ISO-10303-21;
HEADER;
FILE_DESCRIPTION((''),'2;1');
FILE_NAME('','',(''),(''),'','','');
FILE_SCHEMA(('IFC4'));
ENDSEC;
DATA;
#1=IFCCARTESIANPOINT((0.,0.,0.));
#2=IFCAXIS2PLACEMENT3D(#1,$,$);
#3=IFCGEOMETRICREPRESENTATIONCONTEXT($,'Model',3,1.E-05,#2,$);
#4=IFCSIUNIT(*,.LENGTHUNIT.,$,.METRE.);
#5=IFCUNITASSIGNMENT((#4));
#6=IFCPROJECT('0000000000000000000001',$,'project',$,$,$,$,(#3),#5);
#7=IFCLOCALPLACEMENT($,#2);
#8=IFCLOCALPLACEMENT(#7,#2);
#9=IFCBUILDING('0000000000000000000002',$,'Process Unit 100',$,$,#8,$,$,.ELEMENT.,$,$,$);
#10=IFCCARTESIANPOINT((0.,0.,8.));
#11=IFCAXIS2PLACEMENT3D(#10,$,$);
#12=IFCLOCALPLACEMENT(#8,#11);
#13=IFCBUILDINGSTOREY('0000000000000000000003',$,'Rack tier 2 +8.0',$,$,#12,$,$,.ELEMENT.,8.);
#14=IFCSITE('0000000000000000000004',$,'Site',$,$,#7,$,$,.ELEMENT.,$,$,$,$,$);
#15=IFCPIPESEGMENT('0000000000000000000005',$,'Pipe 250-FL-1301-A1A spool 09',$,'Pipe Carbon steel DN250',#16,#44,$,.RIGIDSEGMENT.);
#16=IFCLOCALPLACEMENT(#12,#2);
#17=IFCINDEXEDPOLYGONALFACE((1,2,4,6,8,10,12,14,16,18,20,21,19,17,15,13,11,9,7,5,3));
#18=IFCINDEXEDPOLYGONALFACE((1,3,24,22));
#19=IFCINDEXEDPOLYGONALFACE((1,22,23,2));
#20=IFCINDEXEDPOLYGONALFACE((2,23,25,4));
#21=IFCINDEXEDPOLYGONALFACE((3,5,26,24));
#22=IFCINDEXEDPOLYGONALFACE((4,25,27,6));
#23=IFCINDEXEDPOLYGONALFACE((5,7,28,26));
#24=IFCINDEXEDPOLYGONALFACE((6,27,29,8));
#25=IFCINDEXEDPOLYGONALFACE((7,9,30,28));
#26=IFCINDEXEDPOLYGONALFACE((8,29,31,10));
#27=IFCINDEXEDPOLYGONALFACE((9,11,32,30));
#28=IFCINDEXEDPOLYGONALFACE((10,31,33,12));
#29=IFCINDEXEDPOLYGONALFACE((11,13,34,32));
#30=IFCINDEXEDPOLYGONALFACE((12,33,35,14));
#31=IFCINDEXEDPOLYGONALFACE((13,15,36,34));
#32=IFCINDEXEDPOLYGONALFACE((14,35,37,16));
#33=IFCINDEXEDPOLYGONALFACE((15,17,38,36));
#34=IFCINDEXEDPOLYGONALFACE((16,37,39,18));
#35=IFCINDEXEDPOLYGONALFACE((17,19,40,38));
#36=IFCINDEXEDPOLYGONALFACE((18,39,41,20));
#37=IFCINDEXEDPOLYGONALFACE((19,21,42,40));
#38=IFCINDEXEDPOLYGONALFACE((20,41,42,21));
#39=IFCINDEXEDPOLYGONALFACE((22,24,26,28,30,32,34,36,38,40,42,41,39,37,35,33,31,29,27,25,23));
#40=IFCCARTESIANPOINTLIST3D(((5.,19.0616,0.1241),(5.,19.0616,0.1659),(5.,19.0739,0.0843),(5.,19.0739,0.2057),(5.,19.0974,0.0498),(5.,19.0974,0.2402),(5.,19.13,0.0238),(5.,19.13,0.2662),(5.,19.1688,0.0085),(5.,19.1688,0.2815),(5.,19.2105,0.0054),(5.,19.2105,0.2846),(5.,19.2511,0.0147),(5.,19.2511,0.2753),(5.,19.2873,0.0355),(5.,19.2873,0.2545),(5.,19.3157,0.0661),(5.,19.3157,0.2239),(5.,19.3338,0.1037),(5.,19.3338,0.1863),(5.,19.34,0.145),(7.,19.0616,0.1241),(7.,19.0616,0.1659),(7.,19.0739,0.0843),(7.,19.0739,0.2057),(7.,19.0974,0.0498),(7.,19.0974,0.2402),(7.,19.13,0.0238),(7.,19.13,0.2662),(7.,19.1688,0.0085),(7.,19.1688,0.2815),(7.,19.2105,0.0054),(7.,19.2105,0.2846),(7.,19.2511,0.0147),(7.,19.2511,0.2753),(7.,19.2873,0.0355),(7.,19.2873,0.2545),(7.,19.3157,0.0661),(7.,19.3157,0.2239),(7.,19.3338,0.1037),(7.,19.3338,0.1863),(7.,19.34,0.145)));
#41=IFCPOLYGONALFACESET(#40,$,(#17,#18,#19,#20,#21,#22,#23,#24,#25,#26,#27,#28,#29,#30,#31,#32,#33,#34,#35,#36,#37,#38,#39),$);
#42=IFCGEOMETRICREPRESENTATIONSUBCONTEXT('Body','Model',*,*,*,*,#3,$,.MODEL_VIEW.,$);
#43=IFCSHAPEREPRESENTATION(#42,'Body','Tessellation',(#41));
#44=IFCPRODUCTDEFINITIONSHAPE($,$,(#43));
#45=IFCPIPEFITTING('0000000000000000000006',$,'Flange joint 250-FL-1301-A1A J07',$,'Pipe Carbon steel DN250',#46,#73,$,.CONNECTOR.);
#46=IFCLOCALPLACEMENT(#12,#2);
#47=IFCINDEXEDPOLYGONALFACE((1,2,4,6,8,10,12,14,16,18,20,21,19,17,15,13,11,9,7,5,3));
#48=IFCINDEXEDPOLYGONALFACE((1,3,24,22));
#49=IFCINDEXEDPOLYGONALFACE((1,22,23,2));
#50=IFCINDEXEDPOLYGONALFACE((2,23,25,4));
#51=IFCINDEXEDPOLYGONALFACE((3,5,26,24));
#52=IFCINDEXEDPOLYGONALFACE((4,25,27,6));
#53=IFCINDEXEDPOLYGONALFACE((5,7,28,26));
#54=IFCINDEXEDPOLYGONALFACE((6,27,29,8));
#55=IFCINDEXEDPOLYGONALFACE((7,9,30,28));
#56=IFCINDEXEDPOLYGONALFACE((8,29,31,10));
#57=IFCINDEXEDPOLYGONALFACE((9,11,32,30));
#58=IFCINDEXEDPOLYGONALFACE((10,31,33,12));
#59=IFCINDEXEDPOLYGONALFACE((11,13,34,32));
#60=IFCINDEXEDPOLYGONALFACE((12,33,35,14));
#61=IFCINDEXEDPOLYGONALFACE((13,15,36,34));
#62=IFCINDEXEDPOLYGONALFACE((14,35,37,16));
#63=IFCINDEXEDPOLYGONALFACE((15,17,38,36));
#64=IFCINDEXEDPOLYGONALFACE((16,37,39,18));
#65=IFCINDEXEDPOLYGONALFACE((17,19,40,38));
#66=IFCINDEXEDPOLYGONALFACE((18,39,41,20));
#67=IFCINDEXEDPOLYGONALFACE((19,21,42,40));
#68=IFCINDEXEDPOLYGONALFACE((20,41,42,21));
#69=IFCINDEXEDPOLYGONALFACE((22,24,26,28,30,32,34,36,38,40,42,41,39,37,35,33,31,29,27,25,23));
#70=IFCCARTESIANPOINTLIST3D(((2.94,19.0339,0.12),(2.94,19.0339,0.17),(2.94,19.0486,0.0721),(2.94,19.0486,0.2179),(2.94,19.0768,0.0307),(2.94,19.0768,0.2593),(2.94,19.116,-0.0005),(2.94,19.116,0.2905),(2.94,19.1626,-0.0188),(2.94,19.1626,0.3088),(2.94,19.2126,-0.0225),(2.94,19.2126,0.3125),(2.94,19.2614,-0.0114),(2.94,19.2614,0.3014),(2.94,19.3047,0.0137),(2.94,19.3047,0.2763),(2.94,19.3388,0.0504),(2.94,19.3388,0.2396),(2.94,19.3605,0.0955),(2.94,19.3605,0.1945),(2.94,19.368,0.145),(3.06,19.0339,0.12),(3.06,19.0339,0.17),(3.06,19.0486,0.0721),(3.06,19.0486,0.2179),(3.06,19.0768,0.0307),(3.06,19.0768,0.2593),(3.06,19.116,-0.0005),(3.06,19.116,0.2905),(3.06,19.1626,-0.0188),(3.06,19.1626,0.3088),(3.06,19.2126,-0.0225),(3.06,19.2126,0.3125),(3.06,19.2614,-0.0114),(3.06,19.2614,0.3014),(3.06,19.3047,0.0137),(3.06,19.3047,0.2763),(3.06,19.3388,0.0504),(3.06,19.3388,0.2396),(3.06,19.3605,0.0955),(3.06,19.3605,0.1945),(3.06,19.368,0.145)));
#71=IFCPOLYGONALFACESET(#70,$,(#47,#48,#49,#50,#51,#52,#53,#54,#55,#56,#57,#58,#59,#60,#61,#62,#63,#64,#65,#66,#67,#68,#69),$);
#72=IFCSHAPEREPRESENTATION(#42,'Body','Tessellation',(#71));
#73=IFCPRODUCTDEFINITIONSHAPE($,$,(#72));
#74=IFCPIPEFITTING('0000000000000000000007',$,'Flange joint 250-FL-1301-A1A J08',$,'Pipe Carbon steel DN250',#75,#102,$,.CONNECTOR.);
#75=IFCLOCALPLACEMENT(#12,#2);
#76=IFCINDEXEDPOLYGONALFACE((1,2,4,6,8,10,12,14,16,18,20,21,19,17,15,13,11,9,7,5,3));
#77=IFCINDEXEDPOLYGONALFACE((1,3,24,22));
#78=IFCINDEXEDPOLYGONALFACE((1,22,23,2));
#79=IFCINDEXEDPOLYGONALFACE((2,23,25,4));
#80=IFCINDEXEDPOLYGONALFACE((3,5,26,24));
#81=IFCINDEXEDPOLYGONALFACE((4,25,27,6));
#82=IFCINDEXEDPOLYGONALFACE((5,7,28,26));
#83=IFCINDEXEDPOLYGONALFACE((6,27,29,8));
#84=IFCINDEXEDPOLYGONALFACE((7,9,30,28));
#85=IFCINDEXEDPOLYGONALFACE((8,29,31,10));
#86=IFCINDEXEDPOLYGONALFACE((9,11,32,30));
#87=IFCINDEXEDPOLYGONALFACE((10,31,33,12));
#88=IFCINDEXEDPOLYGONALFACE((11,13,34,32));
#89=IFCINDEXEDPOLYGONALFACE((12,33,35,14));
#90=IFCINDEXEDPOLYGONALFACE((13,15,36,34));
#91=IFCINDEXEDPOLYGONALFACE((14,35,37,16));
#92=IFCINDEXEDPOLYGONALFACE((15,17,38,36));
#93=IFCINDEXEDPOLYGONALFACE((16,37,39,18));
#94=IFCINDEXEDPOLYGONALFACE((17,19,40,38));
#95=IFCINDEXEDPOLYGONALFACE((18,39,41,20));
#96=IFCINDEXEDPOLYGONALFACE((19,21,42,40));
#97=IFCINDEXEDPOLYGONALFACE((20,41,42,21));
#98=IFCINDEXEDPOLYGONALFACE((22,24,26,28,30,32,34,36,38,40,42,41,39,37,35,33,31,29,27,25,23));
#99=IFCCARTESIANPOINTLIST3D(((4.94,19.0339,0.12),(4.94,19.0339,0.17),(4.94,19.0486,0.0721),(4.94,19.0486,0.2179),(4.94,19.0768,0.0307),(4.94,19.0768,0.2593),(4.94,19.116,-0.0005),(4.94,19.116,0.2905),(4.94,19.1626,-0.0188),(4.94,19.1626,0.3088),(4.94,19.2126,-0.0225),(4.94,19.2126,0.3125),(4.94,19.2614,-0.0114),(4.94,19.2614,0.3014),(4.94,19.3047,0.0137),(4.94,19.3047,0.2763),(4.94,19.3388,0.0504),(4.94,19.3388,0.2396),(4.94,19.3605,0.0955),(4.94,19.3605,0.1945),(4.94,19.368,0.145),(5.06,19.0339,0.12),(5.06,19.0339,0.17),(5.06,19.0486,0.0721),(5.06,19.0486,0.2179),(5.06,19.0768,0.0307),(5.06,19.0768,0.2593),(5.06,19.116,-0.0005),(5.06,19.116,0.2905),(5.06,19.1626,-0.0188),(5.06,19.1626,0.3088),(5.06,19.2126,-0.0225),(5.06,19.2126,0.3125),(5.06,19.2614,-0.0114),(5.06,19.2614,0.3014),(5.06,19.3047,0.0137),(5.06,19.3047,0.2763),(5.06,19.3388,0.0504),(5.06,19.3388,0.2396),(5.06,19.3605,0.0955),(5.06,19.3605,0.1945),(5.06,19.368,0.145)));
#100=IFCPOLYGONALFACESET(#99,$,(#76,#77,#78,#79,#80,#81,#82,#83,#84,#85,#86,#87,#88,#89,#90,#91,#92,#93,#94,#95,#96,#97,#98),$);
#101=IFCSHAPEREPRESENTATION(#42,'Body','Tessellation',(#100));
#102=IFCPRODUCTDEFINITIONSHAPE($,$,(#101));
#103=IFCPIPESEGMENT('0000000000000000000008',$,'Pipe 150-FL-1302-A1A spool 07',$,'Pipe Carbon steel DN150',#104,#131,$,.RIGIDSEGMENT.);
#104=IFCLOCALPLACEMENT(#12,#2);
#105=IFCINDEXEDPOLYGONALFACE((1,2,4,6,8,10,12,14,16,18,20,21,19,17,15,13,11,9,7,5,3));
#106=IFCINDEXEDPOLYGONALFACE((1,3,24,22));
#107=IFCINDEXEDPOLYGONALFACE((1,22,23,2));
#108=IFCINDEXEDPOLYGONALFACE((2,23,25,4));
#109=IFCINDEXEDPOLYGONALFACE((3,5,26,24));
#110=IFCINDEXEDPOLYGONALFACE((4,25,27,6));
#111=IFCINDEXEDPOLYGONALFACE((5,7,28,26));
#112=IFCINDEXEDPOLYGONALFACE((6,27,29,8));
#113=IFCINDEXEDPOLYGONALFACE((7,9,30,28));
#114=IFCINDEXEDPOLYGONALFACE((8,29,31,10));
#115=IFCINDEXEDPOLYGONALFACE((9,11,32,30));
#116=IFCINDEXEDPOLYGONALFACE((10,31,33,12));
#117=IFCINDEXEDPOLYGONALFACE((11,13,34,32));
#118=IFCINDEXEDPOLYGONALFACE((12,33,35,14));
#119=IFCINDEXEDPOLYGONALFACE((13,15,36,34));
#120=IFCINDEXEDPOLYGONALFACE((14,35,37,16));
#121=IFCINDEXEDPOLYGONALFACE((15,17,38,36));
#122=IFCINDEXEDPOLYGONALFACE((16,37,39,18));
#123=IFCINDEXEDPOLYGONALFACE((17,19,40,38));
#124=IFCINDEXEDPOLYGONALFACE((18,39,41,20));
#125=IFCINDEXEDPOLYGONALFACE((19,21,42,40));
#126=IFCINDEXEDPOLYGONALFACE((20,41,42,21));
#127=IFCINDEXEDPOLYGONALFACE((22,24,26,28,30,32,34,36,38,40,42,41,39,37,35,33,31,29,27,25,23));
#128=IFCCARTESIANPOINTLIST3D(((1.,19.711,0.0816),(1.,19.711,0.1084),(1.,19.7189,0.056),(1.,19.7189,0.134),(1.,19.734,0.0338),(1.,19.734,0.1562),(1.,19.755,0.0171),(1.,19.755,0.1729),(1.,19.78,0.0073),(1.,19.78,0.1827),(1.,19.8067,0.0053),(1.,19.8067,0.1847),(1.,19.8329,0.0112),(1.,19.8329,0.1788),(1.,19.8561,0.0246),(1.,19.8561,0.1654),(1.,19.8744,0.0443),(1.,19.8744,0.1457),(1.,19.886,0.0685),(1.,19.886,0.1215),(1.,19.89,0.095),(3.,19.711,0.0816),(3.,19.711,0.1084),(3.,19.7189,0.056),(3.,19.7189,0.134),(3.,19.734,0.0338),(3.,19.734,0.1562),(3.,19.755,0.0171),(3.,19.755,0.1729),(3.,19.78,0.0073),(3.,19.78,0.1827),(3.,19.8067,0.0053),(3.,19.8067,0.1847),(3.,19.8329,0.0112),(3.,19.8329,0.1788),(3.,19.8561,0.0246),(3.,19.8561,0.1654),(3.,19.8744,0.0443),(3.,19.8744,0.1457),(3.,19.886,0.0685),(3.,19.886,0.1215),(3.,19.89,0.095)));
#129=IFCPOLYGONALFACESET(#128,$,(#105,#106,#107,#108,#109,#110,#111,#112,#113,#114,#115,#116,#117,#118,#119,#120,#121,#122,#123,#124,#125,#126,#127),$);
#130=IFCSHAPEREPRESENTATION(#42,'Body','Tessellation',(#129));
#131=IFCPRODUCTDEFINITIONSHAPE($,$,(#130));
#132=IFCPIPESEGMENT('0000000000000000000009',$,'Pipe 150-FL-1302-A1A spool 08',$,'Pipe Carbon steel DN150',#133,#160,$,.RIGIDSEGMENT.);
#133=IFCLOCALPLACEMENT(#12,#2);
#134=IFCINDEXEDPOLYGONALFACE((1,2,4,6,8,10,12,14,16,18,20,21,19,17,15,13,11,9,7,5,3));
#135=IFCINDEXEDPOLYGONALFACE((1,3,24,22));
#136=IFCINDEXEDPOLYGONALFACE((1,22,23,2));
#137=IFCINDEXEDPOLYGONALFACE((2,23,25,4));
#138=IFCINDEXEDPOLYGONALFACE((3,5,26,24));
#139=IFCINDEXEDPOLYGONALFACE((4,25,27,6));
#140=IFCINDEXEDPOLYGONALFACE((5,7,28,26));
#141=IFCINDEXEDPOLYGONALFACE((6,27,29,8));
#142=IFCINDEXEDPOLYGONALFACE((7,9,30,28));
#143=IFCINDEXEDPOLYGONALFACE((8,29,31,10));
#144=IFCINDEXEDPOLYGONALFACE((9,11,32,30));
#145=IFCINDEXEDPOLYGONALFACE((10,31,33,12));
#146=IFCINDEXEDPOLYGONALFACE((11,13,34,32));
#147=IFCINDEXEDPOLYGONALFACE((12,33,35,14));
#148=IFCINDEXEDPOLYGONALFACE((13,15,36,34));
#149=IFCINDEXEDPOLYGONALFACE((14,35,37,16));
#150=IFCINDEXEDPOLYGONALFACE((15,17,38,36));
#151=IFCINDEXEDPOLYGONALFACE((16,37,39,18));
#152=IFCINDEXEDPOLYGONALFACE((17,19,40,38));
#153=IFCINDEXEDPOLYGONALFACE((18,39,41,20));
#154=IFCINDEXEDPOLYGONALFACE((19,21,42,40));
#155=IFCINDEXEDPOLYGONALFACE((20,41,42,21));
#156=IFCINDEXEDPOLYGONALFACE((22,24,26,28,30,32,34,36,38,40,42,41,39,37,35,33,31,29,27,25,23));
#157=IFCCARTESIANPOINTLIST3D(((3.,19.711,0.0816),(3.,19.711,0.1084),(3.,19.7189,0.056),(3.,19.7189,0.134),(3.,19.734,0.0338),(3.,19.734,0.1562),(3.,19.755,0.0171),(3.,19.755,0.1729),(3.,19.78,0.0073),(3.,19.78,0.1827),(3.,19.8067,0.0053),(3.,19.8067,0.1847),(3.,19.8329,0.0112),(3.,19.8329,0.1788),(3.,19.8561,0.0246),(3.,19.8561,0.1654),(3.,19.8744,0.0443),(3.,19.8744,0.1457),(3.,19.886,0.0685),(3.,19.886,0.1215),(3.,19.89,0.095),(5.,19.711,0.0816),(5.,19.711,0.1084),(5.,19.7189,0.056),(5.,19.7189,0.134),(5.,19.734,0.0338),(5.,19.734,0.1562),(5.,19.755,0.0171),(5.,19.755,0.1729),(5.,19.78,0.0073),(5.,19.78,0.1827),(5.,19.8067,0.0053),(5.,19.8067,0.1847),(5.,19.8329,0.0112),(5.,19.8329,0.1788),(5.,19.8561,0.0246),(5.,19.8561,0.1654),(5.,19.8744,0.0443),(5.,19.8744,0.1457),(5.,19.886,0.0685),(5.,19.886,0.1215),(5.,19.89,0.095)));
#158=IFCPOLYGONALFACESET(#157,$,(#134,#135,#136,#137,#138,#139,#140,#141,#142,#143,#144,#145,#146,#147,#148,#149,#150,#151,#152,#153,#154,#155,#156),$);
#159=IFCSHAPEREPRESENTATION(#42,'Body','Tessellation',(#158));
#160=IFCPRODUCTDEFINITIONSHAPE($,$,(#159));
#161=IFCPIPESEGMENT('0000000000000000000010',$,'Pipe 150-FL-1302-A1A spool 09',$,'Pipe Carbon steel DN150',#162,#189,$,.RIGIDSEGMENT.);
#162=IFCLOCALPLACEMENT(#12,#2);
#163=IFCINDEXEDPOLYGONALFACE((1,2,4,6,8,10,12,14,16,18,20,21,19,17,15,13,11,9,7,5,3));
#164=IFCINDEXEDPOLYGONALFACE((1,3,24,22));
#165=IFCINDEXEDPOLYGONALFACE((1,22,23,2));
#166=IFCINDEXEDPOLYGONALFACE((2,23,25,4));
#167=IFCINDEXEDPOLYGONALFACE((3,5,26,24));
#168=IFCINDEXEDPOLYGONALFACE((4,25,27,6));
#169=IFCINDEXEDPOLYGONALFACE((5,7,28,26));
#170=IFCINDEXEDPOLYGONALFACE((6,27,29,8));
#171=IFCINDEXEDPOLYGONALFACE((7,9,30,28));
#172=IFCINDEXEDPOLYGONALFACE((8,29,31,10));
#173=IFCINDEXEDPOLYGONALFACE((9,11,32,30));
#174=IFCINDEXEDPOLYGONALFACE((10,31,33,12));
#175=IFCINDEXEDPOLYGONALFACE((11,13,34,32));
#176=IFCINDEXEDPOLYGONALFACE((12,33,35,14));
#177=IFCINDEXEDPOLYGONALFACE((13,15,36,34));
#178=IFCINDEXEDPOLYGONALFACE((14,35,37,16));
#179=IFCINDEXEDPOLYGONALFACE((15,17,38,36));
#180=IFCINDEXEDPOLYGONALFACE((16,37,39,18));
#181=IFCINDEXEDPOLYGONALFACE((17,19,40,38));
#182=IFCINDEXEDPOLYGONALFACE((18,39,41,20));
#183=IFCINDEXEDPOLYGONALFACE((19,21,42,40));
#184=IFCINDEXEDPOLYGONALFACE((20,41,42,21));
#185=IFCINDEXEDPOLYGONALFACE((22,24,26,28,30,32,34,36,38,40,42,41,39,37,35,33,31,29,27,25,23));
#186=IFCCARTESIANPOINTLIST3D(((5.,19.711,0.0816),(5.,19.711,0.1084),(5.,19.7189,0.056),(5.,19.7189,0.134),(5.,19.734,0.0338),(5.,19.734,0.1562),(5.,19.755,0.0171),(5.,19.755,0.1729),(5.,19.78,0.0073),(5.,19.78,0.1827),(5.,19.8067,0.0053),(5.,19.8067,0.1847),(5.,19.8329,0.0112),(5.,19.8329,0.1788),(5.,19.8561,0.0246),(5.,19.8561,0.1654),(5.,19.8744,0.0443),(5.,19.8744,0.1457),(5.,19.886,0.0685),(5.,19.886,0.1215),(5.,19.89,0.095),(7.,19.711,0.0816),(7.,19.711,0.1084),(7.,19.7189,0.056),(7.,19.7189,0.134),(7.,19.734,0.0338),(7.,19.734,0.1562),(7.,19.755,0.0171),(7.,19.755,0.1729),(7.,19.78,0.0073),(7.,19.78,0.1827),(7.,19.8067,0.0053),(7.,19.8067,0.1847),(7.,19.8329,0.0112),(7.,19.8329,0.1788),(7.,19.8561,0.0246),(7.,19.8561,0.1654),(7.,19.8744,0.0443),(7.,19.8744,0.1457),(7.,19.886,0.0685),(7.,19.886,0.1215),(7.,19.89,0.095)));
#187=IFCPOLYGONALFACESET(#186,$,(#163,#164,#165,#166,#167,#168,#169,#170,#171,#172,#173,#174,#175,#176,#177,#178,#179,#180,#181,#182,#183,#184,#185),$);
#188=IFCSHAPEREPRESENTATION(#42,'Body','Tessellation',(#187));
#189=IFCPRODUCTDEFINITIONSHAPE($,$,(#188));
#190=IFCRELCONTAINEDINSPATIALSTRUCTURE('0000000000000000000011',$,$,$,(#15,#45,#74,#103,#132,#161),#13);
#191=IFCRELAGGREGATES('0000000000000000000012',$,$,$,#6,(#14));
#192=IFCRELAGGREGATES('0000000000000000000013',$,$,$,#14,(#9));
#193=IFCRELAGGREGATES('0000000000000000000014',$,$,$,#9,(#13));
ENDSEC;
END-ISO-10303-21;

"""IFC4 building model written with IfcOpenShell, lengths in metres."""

from ifc_helpers import new_model, si_unit, frame, origin, place, context, subcontext, project, spatial, circle, extrude, element, save


model = new_model("IFC4")

# Units and contexts
model_context = context("Model", 3, precision=1e-05, world=origin())
body_context = subcontext(model_context, "Body", "Model", "MODEL_VIEW")
ifc_project = project(units=[si_unit("LENGTHUNIT", "METRE")], contexts=[model_context])

# Site, building, storey
site_placement = place(None, origin())
site = spatial("IfcSite", under=ifc_project, at=site_placement, Name="Site", CompositionType="ELEMENT")
building_placement = place(site_placement, origin())
building = spatial("IfcBuilding", under=site, at=building_placement, Name="Process Unit 100", CompositionType="ELEMENT")
storey_placement = place(building_placement, frame((0.0, 0.0, 8.0)))
storey = spatial("IfcBuildingStorey", under=building, at=storey_placement, Name="Rack tier 2 +8.0", CompositionType="ELEMENT", Elevation=8.0)

# Pipe segment
for number, where, z_axis, x_axis, name in (
    (1, (5.0, 19.2, 0.145), (1.0, 0.0, 0.0), (0.0, 1.0, 0.0), "Pipe 250-FL-1301-A1A spool 09"),
):
    element("IfcPipeSegment", number, at=place(storey_placement, frame(where, z_axis=z_axis, x_axis=x_axis)), inside=storey, Name=name, ObjectType="Pipe Carbon steel DN250", PredefinedType="RIGIDSEGMENT", context=body_context, shape_type="SweptSolid", body=[
        extrude(circle(Radius=0.14), origin(), (0.0, 0.0, 1.0), 2.0),
    ])

# Pipe fittings
for number, where, z_axis, x_axis, name in (
    (2, (2.94, 19.2, 0.145), (1.0, 0.0, 0.0), (0.0, 1.0, 0.0), "Flange joint 250-FL-1301-A1A J07"),
    (3, (4.94, 19.2, 0.145), (1.0, 0.0, 0.0), (0.0, 1.0, 0.0), "Flange joint 250-FL-1301-A1A J08"),
):
    element("IfcPipeFitting", number, at=place(storey_placement, frame(where, z_axis=z_axis, x_axis=x_axis)), inside=storey, Name=name, ObjectType="Pipe Carbon steel DN250", PredefinedType="CONNECTOR", context=body_context, shape_type="SweptSolid", body=[
        extrude(circle(Radius=0.168), origin(), (0.0, 0.0, 1.0), 0.12),
    ])

# Pipe segments
for number, where, z_axis, x_axis, name in (
    (4, (1.0, 19.8, 0.095), (1.0, 0.0, 0.0), (0.0, 1.0, 0.0), "Pipe 150-FL-1302-A1A spool 07"),
    (5, (3.0, 19.8, 0.095), (1.0, 0.0, 0.0), (0.0, 1.0, 0.0), "Pipe 150-FL-1302-A1A spool 08"),
    (6, (5.0, 19.8, 0.095), (1.0, 0.0, 0.0), (0.0, 1.0, 0.0), "Pipe 150-FL-1302-A1A spool 09"),
):
    element("IfcPipeSegment", number, at=place(storey_placement, frame(where, z_axis=z_axis, x_axis=x_axis)), inside=storey, Name=name, ObjectType="Pipe Carbon steel DN150", PredefinedType="RIGIDSEGMENT", context=body_context, shape_type="SweptSolid", body=[
        extrude(circle(Radius=0.09), origin(), (0.0, 0.0, 1.0), 2.0),
    ])

save(model, "model.ifc")
